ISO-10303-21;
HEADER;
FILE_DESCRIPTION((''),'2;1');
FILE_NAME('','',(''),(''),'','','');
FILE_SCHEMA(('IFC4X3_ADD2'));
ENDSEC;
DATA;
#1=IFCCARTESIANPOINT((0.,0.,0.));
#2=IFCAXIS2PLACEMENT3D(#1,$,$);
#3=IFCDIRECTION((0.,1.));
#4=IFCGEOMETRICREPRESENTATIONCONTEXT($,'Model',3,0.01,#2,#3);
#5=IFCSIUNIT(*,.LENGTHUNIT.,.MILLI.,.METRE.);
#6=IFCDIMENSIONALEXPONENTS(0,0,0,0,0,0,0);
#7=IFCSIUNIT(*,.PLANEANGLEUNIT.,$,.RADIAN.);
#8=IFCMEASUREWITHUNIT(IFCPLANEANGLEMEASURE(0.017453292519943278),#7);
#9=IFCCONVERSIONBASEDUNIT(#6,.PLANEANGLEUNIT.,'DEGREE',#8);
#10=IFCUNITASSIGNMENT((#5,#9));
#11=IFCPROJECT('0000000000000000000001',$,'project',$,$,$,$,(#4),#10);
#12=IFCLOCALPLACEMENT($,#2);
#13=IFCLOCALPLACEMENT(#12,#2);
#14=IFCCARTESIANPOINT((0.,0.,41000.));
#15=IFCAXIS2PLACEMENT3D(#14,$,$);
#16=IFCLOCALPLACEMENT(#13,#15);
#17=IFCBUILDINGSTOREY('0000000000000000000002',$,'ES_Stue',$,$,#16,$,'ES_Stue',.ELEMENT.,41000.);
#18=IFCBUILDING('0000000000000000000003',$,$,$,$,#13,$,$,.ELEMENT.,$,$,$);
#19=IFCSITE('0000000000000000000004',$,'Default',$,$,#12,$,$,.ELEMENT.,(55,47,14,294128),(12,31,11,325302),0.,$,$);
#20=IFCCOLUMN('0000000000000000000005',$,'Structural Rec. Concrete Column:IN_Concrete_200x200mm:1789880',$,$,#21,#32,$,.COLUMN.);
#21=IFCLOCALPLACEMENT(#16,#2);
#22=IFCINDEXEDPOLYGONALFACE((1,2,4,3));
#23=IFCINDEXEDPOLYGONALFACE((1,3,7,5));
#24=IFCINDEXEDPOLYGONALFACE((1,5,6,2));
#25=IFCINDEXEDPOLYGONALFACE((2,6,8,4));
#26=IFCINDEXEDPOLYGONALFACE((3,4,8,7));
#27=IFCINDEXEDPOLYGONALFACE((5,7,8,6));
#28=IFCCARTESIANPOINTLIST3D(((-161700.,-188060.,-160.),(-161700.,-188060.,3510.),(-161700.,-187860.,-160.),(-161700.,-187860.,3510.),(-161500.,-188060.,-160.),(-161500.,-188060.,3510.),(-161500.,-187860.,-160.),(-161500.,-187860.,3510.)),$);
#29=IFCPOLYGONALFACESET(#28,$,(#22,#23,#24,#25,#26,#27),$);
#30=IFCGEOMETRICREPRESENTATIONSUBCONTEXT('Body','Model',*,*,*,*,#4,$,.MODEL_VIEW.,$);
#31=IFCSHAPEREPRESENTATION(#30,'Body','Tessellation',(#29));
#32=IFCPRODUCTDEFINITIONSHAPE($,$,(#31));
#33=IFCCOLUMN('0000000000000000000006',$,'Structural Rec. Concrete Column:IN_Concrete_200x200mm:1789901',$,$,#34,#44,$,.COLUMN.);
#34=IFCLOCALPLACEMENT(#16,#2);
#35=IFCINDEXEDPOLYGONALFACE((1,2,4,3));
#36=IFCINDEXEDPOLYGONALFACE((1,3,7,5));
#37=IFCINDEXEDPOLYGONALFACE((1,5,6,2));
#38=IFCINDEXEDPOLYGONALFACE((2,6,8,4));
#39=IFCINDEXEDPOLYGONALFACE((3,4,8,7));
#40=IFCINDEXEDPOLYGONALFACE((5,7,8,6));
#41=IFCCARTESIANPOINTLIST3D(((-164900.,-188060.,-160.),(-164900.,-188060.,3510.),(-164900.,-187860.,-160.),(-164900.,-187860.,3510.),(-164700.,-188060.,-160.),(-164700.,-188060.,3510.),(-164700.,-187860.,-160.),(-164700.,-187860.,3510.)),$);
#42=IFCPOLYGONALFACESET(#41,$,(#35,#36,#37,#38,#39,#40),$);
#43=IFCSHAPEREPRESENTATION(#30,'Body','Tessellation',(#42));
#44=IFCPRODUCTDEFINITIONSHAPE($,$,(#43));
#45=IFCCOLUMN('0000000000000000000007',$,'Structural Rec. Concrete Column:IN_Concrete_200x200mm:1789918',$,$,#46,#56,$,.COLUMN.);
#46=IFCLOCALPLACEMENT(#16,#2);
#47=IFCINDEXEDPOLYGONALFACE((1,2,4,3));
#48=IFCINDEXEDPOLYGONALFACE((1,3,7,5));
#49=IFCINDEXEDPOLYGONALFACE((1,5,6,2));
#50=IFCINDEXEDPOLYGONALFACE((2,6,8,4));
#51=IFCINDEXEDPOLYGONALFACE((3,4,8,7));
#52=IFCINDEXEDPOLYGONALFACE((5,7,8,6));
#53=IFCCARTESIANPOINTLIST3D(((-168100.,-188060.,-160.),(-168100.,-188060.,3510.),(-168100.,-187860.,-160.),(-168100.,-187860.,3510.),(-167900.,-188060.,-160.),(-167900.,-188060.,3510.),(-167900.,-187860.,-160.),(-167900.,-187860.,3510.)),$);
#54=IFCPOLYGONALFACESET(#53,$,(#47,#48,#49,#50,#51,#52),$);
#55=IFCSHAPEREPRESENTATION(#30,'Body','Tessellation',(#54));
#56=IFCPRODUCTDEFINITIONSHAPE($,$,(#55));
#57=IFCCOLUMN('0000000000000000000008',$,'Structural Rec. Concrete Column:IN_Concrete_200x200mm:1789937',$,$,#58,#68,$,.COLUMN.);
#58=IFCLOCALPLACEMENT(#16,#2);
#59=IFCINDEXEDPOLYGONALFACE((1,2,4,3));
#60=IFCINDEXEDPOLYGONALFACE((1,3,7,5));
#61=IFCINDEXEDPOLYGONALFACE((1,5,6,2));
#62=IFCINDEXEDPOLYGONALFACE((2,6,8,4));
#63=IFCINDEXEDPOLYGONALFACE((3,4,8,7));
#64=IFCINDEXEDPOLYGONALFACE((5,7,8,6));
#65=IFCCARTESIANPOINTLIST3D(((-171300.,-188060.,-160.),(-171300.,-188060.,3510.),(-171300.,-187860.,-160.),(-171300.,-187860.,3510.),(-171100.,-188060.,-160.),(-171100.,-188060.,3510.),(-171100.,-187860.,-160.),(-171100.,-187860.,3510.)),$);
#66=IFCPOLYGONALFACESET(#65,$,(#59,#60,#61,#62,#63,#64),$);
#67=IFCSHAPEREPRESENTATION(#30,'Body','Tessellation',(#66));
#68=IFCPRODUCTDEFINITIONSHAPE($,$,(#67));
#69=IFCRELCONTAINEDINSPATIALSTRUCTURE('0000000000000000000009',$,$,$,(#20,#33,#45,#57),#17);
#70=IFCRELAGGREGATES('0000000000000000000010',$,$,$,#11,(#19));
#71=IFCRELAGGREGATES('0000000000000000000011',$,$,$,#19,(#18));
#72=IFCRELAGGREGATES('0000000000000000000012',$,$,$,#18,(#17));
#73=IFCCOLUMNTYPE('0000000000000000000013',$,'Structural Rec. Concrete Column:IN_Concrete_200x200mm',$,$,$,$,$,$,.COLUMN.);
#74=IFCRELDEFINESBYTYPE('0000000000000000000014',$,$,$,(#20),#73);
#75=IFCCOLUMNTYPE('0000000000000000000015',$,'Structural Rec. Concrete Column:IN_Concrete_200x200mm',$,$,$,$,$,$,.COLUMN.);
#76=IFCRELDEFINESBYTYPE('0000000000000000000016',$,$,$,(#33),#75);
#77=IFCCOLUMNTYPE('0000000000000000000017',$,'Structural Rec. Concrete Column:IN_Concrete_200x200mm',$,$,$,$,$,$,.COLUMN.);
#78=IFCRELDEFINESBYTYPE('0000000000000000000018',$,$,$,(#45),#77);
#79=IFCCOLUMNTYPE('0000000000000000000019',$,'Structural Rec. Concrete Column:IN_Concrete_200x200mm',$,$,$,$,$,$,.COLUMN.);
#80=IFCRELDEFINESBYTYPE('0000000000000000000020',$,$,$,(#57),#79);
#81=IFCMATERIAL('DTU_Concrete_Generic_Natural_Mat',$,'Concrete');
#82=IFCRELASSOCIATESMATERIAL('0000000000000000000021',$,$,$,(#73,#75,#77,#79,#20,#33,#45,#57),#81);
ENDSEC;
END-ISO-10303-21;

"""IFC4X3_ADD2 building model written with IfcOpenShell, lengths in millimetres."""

from ifc_helpers import new_model, entity, si_unit, converted_unit, direction, frame, frame_2d, origin, place, context, subcontext, project, spatial, rectangle, extrude, source, transform, mapped, material, material_profile, profile_set, profile_usage, type_object, type_shapes, element, save


model = new_model("IFC4X3_ADD2")

# Units and contexts
model_context = context("Model", 3, precision=0.01, world=origin(), true_north=direction((0.0, 1.0)))
body_context = subcontext(model_context, "Body", "Model", "MODEL_VIEW")
ifc_project = project(units=[si_unit("LENGTHUNIT", "METRE", prefix="MILLI"), converted_unit("PLANEANGLEUNIT", "DEGREE", entity("IfcPlaneAngleMeasure", 0.017453292519943278), si_unit("PLANEANGLEUNIT", "RADIAN"), dimensions=[0, 0, 0, 0, 0, 0, 0])], contexts=[model_context])

# Site, building, storey
site_placement = place(None, origin())
site = spatial("IfcSite", under=ifc_project, at=site_placement, Name="Default", CompositionType="ELEMENT", RefLatitude=(55, 47, 14, 294128), RefLongitude=(12, 31, 11, 325302), RefElevation=0.0)
building_placement = place(site_placement, origin())
building = spatial("IfcBuilding", under=site, at=building_placement, CompositionType="ELEMENT")
storey_placement = place(building_placement, frame((0.0, 0.0, 41000.0)))
storey = spatial("IfcBuildingStorey", under=building, at=storey_placement, Name="ES_Stue", LongName="ES_Stue", CompositionType="ELEMENT", Elevation=41000.0)

# Columns
ifc_material = material(Name="DTU_Concrete_Generic_Natural_Mat", Category="Concrete")
ifc_material_profile_1 = material_profile(ifc_material, rectangle(XDim=200.0, YDim=200.0, at=frame_2d((0.0, 0.0), x_axis=(1.0, 0.0))), Name="IN_Concrete_200x200mm")
ifc_profile_set_1 = profile_set([ifc_material_profile_1], Name="IN_Concrete_200x200mm")
ifc_profile_usage_1 = profile_usage(ifc_profile_set_1)
column_type_1 = type_object("IfcColumnType", Name="Structural Rec. Concrete Column:IN_Concrete_200x200mm", PredefinedType="COLUMN", material=ifc_profile_set_1)
shared_shape_1 = source(origin(), body_context, "Body", "SweptSolid", [
    extrude(rectangle(XDim=200.0, YDim=200.0, at=frame_2d((0.0, 0.0), x_axis=(1.0, 0.0))), frame((-161600.0, -187960.0, 40840.0), z_axis=(0.0, 0.0, 1.0), x_axis=(-1.0, 0.0, 0.0)), (0.0, 0.0, 1.0), 3670.0),
])
type_shapes(column_type_1, [shared_shape_1])
column_1_placement = place(storey_placement, frame((0.0, 0.0, -41000.0)))
element("IfcColumn", 1, at=column_1_placement, inside=storey, type_object=column_type_1, material=ifc_profile_usage_1, Name="Structural Rec. Concrete Column:IN_Concrete_200x200mm:1789880", PredefinedType="COLUMN", context=body_context, shape_type="MappedRepresentation", body=[
    mapped(shared_shape_1, transform((0.0, 0.0, 0.0), scale=1.0)),
])
column_type_2 = type_object("IfcColumnType", Name="Structural Rec. Concrete Column:IN_Concrete_200x200mm", PredefinedType="COLUMN", material=ifc_profile_set_1)
shared_shape_2 = source(origin(), body_context, "Body", "SweptSolid", [
    extrude(rectangle(XDim=200.0, YDim=200.0, at=frame_2d((0.0, 0.0), x_axis=(1.0, 0.0))), frame((-164800.0, -187960.0, 40840.0), z_axis=(0.0, 0.0, 1.0), x_axis=(-1.0, 0.0, 0.0)), (0.0, 0.0, 1.0), 3670.0),
])
type_shapes(column_type_2, [shared_shape_2])
column_2_placement = place(storey_placement, frame((0.0, 0.0, -41000.0)))
element("IfcColumn", 2, at=column_2_placement, inside=storey, type_object=column_type_2, material=ifc_profile_usage_1, Name="Structural Rec. Concrete Column:IN_Concrete_200x200mm:1789901", PredefinedType="COLUMN", context=body_context, shape_type="MappedRepresentation", body=[
    mapped(shared_shape_2, transform((0.0, 0.0, 0.0), scale=1.0)),
])
column_type_3 = type_object("IfcColumnType", Name="Structural Rec. Concrete Column:IN_Concrete_200x200mm", PredefinedType="COLUMN", material=ifc_profile_set_1)
shared_shape_3 = source(origin(), body_context, "Body", "SweptSolid", [
    extrude(rectangle(XDim=200.0, YDim=200.0, at=frame_2d((0.0, 0.0), x_axis=(1.0, 0.0))), frame((-168000.0, -187960.0, 40840.0), z_axis=(0.0, 0.0, 1.0), x_axis=(-1.0, 0.0, 0.0)), (0.0, 0.0, 1.0), 3670.0),
])
type_shapes(column_type_3, [shared_shape_3])
column_3_placement = place(storey_placement, frame((0.0, 0.0, -41000.0)))
element("IfcColumn", 3, at=column_3_placement, inside=storey, type_object=column_type_3, material=ifc_profile_usage_1, Name="Structural Rec. Concrete Column:IN_Concrete_200x200mm:1789918", PredefinedType="COLUMN", context=body_context, shape_type="MappedRepresentation", body=[
    mapped(shared_shape_3, transform((0.0, 0.0, 0.0), scale=1.0)),
])
column_type_4 = type_object("IfcColumnType", Name="Structural Rec. Concrete Column:IN_Concrete_200x200mm", PredefinedType="COLUMN", material=ifc_profile_set_1)
shared_shape_4 = source(origin(), body_context, "Body", "SweptSolid", [
    extrude(rectangle(XDim=200.0, YDim=200.0, at=frame_2d((0.0, 0.0), x_axis=(1.0, 0.0))), frame((-171200.0, -187960.0, 40840.0), z_axis=(0.0, 0.0, 1.0), x_axis=(-1.0, 0.0, 0.0)), (0.0, 0.0, 1.0), 3670.0),
])
type_shapes(column_type_4, [shared_shape_4])
column_4_placement = place(storey_placement, frame((0.0, 0.0, -41000.0)))
element("IfcColumn", 4, at=column_4_placement, inside=storey, type_object=column_type_4, material=ifc_profile_usage_1, Name="Structural Rec. Concrete Column:IN_Concrete_200x200mm:1789937", PredefinedType="COLUMN", context=body_context, shape_type="MappedRepresentation", body=[
    mapped(shared_shape_4, transform((0.0, 0.0, 0.0), scale=1.0)),
])

save(model, "model.ifc")
